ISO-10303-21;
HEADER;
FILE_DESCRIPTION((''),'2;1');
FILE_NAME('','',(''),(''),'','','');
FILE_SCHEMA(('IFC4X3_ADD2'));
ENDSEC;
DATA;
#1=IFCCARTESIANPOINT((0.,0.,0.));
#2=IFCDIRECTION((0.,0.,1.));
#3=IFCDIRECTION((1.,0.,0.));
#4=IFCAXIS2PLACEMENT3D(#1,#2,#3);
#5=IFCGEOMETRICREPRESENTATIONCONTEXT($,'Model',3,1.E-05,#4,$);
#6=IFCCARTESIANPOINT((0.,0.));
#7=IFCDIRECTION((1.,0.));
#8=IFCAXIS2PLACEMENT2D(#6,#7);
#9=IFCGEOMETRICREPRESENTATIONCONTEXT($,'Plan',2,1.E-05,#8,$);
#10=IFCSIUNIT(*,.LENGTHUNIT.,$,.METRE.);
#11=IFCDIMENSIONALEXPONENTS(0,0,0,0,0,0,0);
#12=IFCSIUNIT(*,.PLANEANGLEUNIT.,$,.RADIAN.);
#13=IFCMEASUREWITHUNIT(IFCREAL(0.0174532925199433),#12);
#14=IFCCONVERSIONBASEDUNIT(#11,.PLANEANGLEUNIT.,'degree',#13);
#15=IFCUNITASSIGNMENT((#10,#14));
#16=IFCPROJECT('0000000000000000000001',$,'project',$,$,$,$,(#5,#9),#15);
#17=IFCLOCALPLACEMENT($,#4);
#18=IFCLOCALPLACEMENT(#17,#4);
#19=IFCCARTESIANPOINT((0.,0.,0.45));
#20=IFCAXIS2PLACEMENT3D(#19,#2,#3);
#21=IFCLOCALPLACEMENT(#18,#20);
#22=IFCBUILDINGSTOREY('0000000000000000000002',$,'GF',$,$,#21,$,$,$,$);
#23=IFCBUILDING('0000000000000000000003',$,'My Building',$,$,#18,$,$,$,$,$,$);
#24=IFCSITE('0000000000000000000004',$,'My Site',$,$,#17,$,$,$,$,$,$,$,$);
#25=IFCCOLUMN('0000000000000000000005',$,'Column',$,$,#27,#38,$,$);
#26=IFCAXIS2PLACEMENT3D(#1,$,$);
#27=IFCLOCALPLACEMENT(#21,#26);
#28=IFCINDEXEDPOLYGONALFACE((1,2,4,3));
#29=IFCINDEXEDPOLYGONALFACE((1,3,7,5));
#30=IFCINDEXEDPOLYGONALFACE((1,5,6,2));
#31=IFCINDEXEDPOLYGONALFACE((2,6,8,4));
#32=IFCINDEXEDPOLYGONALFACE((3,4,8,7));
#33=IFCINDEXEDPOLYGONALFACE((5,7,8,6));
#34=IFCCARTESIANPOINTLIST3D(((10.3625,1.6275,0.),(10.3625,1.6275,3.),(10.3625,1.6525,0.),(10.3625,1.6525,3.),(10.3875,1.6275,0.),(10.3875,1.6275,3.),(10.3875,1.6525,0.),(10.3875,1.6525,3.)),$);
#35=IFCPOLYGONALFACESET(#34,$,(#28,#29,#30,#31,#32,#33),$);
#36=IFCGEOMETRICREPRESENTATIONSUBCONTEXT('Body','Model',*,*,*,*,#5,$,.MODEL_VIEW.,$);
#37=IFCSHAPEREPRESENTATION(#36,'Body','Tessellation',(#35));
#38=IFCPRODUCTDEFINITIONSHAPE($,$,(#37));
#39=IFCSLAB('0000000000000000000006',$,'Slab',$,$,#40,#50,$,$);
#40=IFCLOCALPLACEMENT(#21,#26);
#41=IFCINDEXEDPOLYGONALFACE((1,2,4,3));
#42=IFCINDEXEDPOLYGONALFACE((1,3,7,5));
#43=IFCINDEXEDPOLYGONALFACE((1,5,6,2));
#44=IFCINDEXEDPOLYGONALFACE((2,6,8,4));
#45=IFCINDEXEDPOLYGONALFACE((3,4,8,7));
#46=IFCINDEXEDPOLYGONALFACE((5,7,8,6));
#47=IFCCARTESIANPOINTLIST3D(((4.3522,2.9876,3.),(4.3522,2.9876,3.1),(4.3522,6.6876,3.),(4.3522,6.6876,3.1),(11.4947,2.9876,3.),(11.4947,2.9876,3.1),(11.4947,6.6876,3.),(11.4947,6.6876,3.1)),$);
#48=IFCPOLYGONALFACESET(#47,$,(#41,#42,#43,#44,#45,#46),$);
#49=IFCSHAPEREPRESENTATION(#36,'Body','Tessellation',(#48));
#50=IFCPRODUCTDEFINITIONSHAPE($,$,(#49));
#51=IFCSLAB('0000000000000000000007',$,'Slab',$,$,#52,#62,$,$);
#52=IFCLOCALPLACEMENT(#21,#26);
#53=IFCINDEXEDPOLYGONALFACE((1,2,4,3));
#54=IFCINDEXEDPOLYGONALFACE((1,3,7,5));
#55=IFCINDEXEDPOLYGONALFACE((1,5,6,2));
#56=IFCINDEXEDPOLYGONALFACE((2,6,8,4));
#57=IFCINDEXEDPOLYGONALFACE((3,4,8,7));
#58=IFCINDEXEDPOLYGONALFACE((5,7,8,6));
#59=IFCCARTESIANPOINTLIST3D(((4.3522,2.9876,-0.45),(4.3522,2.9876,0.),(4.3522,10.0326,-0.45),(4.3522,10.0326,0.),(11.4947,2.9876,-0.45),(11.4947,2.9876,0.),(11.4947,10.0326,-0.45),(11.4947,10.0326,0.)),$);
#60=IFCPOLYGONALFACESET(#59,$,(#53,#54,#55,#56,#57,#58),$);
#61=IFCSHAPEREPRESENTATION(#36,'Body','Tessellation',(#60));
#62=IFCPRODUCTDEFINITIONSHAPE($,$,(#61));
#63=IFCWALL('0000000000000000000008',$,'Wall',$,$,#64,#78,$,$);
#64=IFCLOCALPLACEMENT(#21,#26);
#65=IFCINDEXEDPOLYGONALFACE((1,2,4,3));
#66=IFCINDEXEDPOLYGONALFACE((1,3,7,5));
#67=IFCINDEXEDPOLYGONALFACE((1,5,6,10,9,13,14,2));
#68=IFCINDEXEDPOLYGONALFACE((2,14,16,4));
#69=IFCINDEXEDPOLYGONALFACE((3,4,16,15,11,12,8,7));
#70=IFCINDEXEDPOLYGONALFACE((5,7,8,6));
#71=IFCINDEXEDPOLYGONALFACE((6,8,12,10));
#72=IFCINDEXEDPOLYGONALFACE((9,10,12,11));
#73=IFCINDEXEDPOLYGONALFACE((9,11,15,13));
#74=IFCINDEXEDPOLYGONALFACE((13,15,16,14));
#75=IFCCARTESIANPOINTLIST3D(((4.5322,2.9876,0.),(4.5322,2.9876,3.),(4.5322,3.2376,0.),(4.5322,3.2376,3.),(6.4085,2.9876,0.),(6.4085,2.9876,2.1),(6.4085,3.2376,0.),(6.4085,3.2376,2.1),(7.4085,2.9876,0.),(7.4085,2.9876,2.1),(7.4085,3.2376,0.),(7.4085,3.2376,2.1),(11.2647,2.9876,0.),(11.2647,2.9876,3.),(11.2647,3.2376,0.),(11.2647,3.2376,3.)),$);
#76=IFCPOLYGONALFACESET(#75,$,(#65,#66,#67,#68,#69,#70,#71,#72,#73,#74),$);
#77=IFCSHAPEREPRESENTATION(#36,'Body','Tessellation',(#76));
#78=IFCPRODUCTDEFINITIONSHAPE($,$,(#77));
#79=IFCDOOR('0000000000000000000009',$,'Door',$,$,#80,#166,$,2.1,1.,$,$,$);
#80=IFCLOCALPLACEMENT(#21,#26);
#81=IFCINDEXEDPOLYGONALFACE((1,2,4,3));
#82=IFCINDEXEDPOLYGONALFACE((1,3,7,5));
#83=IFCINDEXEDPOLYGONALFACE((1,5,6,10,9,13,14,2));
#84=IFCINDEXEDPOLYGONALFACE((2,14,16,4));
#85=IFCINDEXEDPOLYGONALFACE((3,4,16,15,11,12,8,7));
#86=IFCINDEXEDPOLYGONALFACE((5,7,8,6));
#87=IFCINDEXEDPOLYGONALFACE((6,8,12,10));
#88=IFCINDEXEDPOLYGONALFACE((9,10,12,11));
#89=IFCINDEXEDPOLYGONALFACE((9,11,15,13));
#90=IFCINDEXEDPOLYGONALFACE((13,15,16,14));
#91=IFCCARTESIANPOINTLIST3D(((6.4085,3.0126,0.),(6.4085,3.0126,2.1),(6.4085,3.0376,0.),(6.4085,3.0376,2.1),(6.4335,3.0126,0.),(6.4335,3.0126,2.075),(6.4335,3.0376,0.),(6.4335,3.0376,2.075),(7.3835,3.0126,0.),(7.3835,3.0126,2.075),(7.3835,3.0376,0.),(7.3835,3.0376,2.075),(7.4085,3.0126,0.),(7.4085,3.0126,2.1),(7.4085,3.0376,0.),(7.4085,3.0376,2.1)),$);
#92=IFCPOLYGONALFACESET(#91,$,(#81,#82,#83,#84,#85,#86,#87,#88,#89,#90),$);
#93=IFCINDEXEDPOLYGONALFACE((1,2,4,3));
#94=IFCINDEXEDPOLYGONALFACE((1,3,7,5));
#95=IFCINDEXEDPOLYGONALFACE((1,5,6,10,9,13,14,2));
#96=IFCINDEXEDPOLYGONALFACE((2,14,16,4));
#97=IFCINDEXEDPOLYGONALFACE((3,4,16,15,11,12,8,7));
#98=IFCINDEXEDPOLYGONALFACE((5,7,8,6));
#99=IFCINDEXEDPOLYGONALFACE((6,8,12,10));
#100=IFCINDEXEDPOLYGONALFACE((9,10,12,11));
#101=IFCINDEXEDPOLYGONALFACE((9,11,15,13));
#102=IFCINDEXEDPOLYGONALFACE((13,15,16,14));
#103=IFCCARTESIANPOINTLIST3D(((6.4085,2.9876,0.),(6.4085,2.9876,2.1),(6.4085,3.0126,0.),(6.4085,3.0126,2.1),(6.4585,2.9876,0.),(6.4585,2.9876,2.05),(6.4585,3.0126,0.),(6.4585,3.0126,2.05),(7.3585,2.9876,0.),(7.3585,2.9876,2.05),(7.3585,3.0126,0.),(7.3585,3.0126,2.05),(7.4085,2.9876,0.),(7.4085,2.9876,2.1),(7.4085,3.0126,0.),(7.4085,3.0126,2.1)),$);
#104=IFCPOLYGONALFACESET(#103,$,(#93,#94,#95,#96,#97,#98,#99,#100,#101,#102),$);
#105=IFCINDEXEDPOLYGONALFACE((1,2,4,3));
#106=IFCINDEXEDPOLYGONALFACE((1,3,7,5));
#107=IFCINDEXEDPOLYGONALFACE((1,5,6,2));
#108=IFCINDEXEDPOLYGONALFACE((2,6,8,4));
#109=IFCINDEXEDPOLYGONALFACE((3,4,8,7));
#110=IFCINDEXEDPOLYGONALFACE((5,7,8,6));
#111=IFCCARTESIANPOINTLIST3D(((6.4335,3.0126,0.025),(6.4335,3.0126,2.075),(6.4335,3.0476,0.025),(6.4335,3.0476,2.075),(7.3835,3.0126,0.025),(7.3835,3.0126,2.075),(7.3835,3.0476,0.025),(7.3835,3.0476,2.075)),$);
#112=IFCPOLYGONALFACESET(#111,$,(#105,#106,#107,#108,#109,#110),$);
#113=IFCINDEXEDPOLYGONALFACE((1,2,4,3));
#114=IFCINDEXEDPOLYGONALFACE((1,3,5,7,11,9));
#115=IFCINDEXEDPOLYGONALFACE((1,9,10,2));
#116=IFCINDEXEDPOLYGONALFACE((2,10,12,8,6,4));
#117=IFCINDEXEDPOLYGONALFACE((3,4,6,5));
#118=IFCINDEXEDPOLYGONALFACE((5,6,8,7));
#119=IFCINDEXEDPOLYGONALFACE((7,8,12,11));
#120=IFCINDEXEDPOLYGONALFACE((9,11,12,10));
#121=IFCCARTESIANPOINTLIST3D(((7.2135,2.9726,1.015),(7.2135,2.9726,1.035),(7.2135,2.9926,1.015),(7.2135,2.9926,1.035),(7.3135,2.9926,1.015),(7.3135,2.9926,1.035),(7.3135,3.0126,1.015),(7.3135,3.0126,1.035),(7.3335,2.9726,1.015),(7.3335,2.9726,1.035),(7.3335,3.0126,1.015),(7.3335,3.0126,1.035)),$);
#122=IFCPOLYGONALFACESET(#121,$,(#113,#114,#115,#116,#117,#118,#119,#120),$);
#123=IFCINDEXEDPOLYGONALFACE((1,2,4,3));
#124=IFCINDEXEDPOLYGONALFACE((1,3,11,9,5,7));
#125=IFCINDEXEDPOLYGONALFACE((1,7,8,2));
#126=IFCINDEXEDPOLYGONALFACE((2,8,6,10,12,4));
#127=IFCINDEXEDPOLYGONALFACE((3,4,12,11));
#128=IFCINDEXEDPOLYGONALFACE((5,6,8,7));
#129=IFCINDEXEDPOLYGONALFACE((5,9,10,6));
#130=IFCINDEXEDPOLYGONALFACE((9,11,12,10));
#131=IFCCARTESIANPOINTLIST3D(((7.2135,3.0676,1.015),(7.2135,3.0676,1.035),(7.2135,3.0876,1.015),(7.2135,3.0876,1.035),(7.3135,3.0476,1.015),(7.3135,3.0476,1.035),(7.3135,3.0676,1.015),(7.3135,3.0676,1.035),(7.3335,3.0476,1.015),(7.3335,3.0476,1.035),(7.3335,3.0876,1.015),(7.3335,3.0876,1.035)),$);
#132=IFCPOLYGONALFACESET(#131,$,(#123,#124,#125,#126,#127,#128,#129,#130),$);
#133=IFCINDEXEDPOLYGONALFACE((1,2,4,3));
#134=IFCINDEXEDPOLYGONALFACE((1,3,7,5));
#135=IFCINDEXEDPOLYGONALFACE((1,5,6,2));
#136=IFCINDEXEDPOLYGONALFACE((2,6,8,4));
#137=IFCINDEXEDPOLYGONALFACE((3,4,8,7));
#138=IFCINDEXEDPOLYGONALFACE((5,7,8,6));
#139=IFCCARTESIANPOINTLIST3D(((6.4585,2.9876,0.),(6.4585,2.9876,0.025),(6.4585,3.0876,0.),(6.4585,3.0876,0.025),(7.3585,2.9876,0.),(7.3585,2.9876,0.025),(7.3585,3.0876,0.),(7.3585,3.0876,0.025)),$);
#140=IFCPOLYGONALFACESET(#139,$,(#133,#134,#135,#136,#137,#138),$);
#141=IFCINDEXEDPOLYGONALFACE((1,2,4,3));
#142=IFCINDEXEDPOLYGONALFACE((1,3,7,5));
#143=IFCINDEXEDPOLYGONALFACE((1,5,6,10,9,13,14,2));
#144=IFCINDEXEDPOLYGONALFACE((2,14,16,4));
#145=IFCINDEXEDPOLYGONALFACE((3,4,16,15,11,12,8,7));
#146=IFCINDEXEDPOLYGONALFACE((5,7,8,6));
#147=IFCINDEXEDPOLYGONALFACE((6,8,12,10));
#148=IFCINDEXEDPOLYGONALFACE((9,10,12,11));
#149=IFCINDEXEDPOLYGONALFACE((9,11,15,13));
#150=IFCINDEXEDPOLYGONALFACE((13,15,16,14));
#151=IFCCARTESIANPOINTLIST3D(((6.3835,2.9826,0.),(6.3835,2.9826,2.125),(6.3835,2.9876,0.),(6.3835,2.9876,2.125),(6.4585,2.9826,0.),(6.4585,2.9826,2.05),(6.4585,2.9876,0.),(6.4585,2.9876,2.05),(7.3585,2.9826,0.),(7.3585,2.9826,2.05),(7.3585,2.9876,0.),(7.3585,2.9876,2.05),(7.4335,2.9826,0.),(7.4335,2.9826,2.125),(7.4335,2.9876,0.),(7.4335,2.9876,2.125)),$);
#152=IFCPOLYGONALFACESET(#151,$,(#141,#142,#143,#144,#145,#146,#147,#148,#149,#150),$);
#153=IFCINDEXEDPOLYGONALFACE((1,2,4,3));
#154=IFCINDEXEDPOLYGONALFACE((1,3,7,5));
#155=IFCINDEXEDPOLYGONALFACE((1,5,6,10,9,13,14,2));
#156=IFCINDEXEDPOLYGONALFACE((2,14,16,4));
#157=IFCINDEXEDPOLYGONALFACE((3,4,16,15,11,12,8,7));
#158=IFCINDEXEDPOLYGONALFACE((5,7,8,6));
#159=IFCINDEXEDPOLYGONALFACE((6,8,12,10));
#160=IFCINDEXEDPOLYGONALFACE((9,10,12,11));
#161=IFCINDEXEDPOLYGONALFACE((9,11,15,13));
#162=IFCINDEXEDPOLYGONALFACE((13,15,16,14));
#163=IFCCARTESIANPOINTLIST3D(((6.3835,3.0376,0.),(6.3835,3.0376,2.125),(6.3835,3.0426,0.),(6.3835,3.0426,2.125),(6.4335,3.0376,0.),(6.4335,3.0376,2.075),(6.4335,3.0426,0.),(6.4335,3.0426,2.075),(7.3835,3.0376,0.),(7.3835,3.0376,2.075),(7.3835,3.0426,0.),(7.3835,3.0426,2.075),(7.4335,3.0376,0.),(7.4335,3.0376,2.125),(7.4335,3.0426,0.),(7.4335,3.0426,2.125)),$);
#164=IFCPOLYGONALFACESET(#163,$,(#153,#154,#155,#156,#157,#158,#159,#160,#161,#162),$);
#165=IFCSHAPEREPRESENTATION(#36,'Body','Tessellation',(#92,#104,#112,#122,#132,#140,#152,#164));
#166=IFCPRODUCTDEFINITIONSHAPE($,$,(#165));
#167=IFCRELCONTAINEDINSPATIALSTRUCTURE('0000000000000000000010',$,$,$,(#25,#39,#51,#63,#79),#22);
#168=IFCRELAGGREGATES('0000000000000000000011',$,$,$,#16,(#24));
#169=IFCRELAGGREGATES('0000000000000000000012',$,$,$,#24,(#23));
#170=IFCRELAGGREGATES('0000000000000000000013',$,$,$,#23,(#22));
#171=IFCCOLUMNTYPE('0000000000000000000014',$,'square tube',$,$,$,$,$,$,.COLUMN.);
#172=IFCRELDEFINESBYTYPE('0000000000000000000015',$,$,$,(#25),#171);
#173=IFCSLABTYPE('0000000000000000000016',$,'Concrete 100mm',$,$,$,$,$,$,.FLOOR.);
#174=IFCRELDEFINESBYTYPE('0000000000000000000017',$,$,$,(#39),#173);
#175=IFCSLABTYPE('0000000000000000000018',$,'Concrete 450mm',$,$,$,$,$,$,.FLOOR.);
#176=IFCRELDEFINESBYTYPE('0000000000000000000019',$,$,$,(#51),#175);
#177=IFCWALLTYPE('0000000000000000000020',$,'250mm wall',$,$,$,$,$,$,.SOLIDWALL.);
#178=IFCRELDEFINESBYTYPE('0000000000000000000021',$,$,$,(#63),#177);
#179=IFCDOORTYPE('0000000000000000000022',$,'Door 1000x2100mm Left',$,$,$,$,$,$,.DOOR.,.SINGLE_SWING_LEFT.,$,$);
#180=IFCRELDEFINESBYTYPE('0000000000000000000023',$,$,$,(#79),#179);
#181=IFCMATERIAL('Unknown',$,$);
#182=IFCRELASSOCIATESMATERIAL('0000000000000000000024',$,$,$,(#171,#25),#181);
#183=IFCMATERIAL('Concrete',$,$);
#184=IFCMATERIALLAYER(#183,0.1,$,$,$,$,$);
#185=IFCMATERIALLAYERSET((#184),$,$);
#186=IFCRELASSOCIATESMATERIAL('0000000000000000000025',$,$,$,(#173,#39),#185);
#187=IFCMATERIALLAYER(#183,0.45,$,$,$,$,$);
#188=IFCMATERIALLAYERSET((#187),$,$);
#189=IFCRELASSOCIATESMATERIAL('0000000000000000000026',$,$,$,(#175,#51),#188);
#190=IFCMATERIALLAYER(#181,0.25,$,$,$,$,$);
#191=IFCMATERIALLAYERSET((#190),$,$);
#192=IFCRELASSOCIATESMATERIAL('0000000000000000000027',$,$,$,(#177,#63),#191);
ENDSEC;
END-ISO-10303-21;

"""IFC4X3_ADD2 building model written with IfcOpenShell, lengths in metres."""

from ifc_helpers import new_model, entity, si_unit, converted_unit, frame, origin_with_axes, origin_2d_with_axis, place, context, subcontext, project, spatial, line, indexed_curve, rectangle, outline, extrude, shape, source, transform, mapped, material, layer, layer_set, layer_usage, material_profile, profile_set, profile_usage, type_object, type_shapes, element, fill, save


model = new_model("IFC4X3_ADD2")

# Units and contexts
model_context = context("Model", 3, precision=1e-05, world=origin_with_axes())
plan_context = context("Plan", 2, precision=1e-05, world=origin_2d_with_axis())
body_context_1 = subcontext(model_context, "Body", "Model", "MODEL_VIEW")
body_context_2 = subcontext(plan_context, "Body", "Plan", "PLAN_VIEW")
ifc_project = project(units=[si_unit("LENGTHUNIT", "METRE"), converted_unit("PLANEANGLEUNIT", "degree", entity("IfcReal", 0.0174532925199433), si_unit("PLANEANGLEUNIT", "RADIAN"), dimensions=[0, 0, 0, 0, 0, 0, 0])], contexts=[model_context, plan_context])

# Site, building, storey
site_placement = place(None, origin_with_axes())
site = spatial("IfcSite", under=ifc_project, at=site_placement, Name="My Site")
building_placement = place(site_placement, origin_with_axes())
building = spatial("IfcBuilding", under=site, at=building_placement, Name="My Building")
storey_placement = place(building_placement, frame((0.0, 0.0, 0.45), z_axis=(0.0, 0.0, 1.0), x_axis=(1.0, 0.0, 0.0)))
storey = spatial("IfcBuildingStorey", under=building, at=storey_placement, Name="GF")

# Column
ifc_material_1 = material(Name="Unknown")
ifc_material_profile = material_profile(ifc_material_1, rectangle(XDim=0.025, YDim=0.025))
ifc_profile_set = profile_set([ifc_material_profile])
ifc_profile_usage = profile_usage(ifc_profile_set, cardinal=5)
column_type = type_object("IfcColumnType", Name="square tube", PredefinedType="COLUMN", material=ifc_profile_set)
column_placement = place(storey_placement, frame((10.375, 1.64, 0.0), z_axis=(0.0, 0.0, 1.0), x_axis=(1.0, 0.0, 0.0)))
element("IfcColumn", 1, at=column_placement, inside=storey, type_object=column_type, material=ifc_profile_usage, Name="Column", context=body_context_1, shape_type="SweptSolid", body=[
    extrude(rectangle(XDim=0.025, YDim=0.025), origin_with_axes(), (0.0, 0.0, 1.0), 3.0),
])

# Slabs
ifc_material_2 = material(Name="Concrete")
ifc_layer_1 = layer(ifc_material_2, 0.1)
ifc_layer_set_1 = layer_set([ifc_layer_1])
slab_type_1 = type_object("IfcSlabType", Name="Concrete 100mm", PredefinedType="FLOOR", material=ifc_layer_set_1)
ifc_layer_usage_1 = layer_usage(ifc_layer_set_1, "AXIS3", "POSITIVE", 0.0)
slab_1_placement = place(storey_placement, frame((4.3522, 2.9876, 3.0), z_axis=(0.0, 0.0, 1.0), x_axis=(1.0, 0.0, 0.0)))
element("IfcSlab", 2, at=slab_1_placement, inside=storey, type_object=slab_type_1, material=ifc_layer_usage_1, Name="Slab", context=body_context_1, shape_type="SolidModel", body=[
    extrude(outline(indexed_curve([(0.0, 0.0), (7.1425, 0.0), (7.1425, 3.7), (0.0, 3.7), (0.0, 0.0)])), origin_with_axes(), (0.0, 0.0, 1.0), 0.1),
])
ifc_layer_2 = layer(ifc_material_2, 0.45)
ifc_layer_set_2 = layer_set([ifc_layer_2])
ifc_layer_usage_2 = layer_usage(ifc_layer_set_2, "AXIS3", "POSITIVE", -0.45)
slab_type_2 = type_object("IfcSlabType", Name="Concrete 450mm", PredefinedType="FLOOR", material=ifc_layer_set_2)
slab_2_placement = place(storey_placement, frame((4.3522, 2.9876, 0.0), z_axis=(0.0, 0.0, 1.0), x_axis=(1.0, 0.0, 0.0)))
element("IfcSlab", 3, at=slab_2_placement, inside=storey, type_object=slab_type_2, material=ifc_layer_usage_2, Name="Slab", context=body_context_1, shape_type="SolidModel", body=[
    extrude(outline(indexed_curve([(0.0, 7.045), (7.1425, 7.045), (7.1425, 0.0), (0.0, 0.0), (0.0, 7.045)])), frame((0.0, 0.0, -0.45), z_axis=(0.0, 0.0, 1.0), x_axis=(1.0, 0.0, 0.0)), (0.0, 0.0, 1.0), 0.45),
])

# Wall, opening, door
ifc_layer_3 = layer(ifc_material_1, 0.25)
ifc_layer_set_3 = layer_set([ifc_layer_3])
ifc_layer_usage_3 = layer_usage(ifc_layer_set_3, "AXIS2", "POSITIVE", 0.0)
wall_type_1 = type_object("IfcWallType", Name="250mm wall", PredefinedType="SOLIDWALL", material=ifc_layer_set_3)
wall_1_placement = place(storey_placement, frame((4.5322, 2.9876, 0.0), z_axis=(0.0, 0.0, 1.0), x_axis=(1.0, 0.0, 0.0)))
wall_1 = element("IfcWall", 4, at=wall_1_placement, inside=storey, type_object=wall_type_1, material=ifc_layer_usage_3, Name="Wall", context=body_context_1, shape_type="SweptSolid", body=[
    extrude(outline(indexed_curve([(0.0, 0.0), (0.0, 0.25), (6.7325, 0.25), (6.7325, 0.0), (0.0, 0.0)], self_intersect=False)), origin_with_axes(), (0.0, 0.0, 1.0), 3.0),
])
shared_shape_1 = source(origin_with_axes(), body_context_1, "Body", "SolidModel", [
    extrude(outline(indexed_curve([(0.0, 0.0), (1.0, 0.0), (1.0, 2.1), (0.0, 2.1)], segments=[line(1, 2, 3, 4, 1)])), frame((0.0, -0.6, 0.0), z_axis=(0.0, -1.0, 0.0), x_axis=(1.0, 0.0, 0.0)), (0.0, 0.0, -1.0), 1.2),
])
opening_1_placement = place(wall_1_placement, frame((1.8763, 0.0, 0.0), z_axis=(0.0, 0.0, 1.0), x_axis=(1.0, 0.0, 0.0)))
opening_1 = element("IfcOpeningElement", 5, at=opening_1_placement, cuts=wall_1, PredefinedType="OPENING", context=body_context_1, shape_type="MappedRepresentation", body=[
    mapped(shared_shape_1, transform((0.0, 0.0, 0.0), x_axis=(1.0, 0.0, 0.0), y_axis=(0.0, 1.0, 0.0), z_axis=(0.0, 0.0, 1.0), scale=1.0)),
])
door_type_1 = type_object("IfcDoorType", Name="Door 1000x2100mm Left", OperationType="SINGLE_SWING_LEFT", PredefinedType="DOOR")
shared_shape_2 = source(origin_with_axes(), body_context_1, "Body", "SweptSolid", [
    extrude(outline(indexed_curve([(0.0, 0.0), (0.0, 2.1), (1.0, 2.1), (1.0, 0.0), (0.975, 0.0), (0.975, 2.075), (0.025, 2.075), (0.025, 0.0)], segments=[line(1, 2, 3, 4, 5, 6, 7, 8, 1)])), frame((0.0, 0.025, 0.0), z_axis=(0.0, -1.0, 0.0), x_axis=(1.0, 0.0, 0.0)), (0.0, 0.0, -1.0), 0.025),
    extrude(outline(indexed_curve([(0.0, 0.0), (0.0, 2.1), (1.0, 2.1), (1.0, 0.0), (0.95, 0.0), (0.95, 2.05), (0.05, 2.05), (0.05, 0.0)], segments=[line(1, 2, 3, 4, 5, 6, 7, 8, 1)])), frame((0.0, 0.0, 0.0), z_axis=(0.0, -1.0, 0.0), x_axis=(1.0, 0.0, 0.0)), (0.0, 0.0, -1.0), 0.025),
    extrude(outline(indexed_curve([(0.0, 0.0), (0.95, 0.0), (0.95, 0.035), (0.0, 0.035)], segments=[line(1, 2, 3, 4, 1)])), frame((0.025, 0.025, 0.025), z_axis=(0.0, 0.0, 1.0), x_axis=(1.0, 0.0, 0.0)), (0.0, 0.0, 1.0), 2.05),
    extrude(outline(indexed_curve([(0.0, 0.0), (0.0, -0.04), (-0.12, -0.04), (-0.12, -0.02), (-0.02, -0.02), (-0.02, 0.0)], segments=[line(1, 2, 3, 4, 5, 6, 1)])), frame((0.925, 0.025, 1.015), z_axis=(0.0, 0.0, 1.0), x_axis=(1.0, 0.0, 0.0)), (0.0, 0.0, 1.0), 0.02),
    extrude(outline(indexed_curve([(0.0, 0.0), (0.0, 0.04), (-0.12, 0.04), (-0.12, 0.02), (-0.02, 0.02), (-0.02, 0.0)], segments=[line(1, 2, 3, 4, 5, 6, 1)])), frame((0.925, 0.06, 1.015), z_axis=(0.0, 0.0, 1.0), x_axis=(1.0, 0.0, 0.0)), (0.0, 0.0, 1.0), 0.02),
    extrude(outline(indexed_curve([(0.0, 0.0), (0.9, 0.0), (0.9, 0.1), (0.0, 0.1)], segments=[line(1, 2, 3, 4, 1)])), frame((0.05, 0.0, 0.0), z_axis=(0.0, 0.0, 1.0), x_axis=(1.0, 0.0, 0.0)), (0.0, 0.0, 1.0), 0.025),
    extrude(outline(indexed_curve([(0.0, 0.0), (0.0, 2.125), (1.05, 2.125), (1.05, 0.0), (0.975, 0.0), (0.975, 2.05), (0.075, 2.05), (0.075, 0.0)], segments=[line(1, 2, 3, 4, 5, 6, 7, 8, 1)])), frame((-0.025, -0.005, 0.0), z_axis=(0.0, -1.0, 0.0), x_axis=(1.0, 0.0, 0.0)), (0.0, 0.0, -1.0), 0.005),
    extrude(outline(indexed_curve([(0.0, 0.0), (0.0, 2.125), (1.05, 2.125), (1.05, 0.0), (1.0, 0.0), (1.0, 2.075), (0.05, 2.075), (0.05, 0.0)], segments=[line(1, 2, 3, 4, 5, 6, 7, 8, 1)])), frame((-0.025, 0.05, 0.0), z_axis=(0.0, -1.0, 0.0), x_axis=(1.0, 0.0, 0.0)), (0.0, 0.0, -1.0), 0.005),
])
shared_shape_3 = source(origin_with_axes(), body_context_2, "Body", "Curve2D", [
    entity("IfcIndexedPolyCurve", entity("IfcCartesianPointList2D", [[0.0, 0.0], [0.0, 0.05], [0.025, 0.05], [0.025, 0.025], [0.05, 0.025], [0.05, 0.0]]), [entity("IfcLineIndex", [1, 2, 3, 4, 5, 6, 1])]),
    entity("IfcIndexedPolyCurve", entity("IfcCartesianPointList2D", [[1.0, 0.0], [1.0, 0.05], [0.975, 0.05], [0.975, 0.025], [0.95, 0.025], [0.95, 0.0]]), [entity("IfcLineIndex", [1, 2, 3, 4, 5, 6, 1])]),
    entity("IfcTrimmedCurve", entity("IfcEllipse", entity("IfcAxis2Placement2D", entity("IfcCartesianPoint", [0.06, 0.05]), entity("IfcDirection", [1.0, 0.0])), 0.915, 0.95), [entity("IfcCartesianPoint", [0.975, 0.05])], [entity("IfcCartesianPoint", [0.06, 1.0])], True, "CARTESIAN"),
    entity("IfcIndexedPolyCurve", entity("IfcCartesianPointList2D", [[0.025, 0.05], [0.06, 0.05], [0.06, 1.0], [0.025, 1.0]]), [entity("IfcLineIndex", [1, 2, 3, 4, 1])]),
])
type_shapes(door_type_1, [shared_shape_2, shared_shape_3])
door_1_placement = place(opening_1_placement, origin_with_axes())
door_1 = element("IfcDoor", 6, at=door_1_placement, inside=storey, type_object=door_type_1, Name="Door", OverallHeight=2.1, OverallWidth=1.0, shapes=[
    shape(body_context_1, "Body", "MappedRepresentation", [mapped(shared_shape_2, transform((0.0, 0.0, 0.0), x_axis=(1.0, 0.0, 0.0), y_axis=(0.0, 1.0, 0.0), z_axis=(0.0, 0.0, 1.0), scale=1.0))]),
    shape(body_context_2, "Body", "MappedRepresentation", [mapped(shared_shape_3, transform((0.0, 0.0, 0.0), x_axis=(1.0, 0.0, 0.0), y_axis=(0.0, 1.0, 0.0), z_axis=(0.0, 0.0, 1.0), scale=1.0))]),
])
fill(opening_1, door_1)

save(model, "model.ifc")
